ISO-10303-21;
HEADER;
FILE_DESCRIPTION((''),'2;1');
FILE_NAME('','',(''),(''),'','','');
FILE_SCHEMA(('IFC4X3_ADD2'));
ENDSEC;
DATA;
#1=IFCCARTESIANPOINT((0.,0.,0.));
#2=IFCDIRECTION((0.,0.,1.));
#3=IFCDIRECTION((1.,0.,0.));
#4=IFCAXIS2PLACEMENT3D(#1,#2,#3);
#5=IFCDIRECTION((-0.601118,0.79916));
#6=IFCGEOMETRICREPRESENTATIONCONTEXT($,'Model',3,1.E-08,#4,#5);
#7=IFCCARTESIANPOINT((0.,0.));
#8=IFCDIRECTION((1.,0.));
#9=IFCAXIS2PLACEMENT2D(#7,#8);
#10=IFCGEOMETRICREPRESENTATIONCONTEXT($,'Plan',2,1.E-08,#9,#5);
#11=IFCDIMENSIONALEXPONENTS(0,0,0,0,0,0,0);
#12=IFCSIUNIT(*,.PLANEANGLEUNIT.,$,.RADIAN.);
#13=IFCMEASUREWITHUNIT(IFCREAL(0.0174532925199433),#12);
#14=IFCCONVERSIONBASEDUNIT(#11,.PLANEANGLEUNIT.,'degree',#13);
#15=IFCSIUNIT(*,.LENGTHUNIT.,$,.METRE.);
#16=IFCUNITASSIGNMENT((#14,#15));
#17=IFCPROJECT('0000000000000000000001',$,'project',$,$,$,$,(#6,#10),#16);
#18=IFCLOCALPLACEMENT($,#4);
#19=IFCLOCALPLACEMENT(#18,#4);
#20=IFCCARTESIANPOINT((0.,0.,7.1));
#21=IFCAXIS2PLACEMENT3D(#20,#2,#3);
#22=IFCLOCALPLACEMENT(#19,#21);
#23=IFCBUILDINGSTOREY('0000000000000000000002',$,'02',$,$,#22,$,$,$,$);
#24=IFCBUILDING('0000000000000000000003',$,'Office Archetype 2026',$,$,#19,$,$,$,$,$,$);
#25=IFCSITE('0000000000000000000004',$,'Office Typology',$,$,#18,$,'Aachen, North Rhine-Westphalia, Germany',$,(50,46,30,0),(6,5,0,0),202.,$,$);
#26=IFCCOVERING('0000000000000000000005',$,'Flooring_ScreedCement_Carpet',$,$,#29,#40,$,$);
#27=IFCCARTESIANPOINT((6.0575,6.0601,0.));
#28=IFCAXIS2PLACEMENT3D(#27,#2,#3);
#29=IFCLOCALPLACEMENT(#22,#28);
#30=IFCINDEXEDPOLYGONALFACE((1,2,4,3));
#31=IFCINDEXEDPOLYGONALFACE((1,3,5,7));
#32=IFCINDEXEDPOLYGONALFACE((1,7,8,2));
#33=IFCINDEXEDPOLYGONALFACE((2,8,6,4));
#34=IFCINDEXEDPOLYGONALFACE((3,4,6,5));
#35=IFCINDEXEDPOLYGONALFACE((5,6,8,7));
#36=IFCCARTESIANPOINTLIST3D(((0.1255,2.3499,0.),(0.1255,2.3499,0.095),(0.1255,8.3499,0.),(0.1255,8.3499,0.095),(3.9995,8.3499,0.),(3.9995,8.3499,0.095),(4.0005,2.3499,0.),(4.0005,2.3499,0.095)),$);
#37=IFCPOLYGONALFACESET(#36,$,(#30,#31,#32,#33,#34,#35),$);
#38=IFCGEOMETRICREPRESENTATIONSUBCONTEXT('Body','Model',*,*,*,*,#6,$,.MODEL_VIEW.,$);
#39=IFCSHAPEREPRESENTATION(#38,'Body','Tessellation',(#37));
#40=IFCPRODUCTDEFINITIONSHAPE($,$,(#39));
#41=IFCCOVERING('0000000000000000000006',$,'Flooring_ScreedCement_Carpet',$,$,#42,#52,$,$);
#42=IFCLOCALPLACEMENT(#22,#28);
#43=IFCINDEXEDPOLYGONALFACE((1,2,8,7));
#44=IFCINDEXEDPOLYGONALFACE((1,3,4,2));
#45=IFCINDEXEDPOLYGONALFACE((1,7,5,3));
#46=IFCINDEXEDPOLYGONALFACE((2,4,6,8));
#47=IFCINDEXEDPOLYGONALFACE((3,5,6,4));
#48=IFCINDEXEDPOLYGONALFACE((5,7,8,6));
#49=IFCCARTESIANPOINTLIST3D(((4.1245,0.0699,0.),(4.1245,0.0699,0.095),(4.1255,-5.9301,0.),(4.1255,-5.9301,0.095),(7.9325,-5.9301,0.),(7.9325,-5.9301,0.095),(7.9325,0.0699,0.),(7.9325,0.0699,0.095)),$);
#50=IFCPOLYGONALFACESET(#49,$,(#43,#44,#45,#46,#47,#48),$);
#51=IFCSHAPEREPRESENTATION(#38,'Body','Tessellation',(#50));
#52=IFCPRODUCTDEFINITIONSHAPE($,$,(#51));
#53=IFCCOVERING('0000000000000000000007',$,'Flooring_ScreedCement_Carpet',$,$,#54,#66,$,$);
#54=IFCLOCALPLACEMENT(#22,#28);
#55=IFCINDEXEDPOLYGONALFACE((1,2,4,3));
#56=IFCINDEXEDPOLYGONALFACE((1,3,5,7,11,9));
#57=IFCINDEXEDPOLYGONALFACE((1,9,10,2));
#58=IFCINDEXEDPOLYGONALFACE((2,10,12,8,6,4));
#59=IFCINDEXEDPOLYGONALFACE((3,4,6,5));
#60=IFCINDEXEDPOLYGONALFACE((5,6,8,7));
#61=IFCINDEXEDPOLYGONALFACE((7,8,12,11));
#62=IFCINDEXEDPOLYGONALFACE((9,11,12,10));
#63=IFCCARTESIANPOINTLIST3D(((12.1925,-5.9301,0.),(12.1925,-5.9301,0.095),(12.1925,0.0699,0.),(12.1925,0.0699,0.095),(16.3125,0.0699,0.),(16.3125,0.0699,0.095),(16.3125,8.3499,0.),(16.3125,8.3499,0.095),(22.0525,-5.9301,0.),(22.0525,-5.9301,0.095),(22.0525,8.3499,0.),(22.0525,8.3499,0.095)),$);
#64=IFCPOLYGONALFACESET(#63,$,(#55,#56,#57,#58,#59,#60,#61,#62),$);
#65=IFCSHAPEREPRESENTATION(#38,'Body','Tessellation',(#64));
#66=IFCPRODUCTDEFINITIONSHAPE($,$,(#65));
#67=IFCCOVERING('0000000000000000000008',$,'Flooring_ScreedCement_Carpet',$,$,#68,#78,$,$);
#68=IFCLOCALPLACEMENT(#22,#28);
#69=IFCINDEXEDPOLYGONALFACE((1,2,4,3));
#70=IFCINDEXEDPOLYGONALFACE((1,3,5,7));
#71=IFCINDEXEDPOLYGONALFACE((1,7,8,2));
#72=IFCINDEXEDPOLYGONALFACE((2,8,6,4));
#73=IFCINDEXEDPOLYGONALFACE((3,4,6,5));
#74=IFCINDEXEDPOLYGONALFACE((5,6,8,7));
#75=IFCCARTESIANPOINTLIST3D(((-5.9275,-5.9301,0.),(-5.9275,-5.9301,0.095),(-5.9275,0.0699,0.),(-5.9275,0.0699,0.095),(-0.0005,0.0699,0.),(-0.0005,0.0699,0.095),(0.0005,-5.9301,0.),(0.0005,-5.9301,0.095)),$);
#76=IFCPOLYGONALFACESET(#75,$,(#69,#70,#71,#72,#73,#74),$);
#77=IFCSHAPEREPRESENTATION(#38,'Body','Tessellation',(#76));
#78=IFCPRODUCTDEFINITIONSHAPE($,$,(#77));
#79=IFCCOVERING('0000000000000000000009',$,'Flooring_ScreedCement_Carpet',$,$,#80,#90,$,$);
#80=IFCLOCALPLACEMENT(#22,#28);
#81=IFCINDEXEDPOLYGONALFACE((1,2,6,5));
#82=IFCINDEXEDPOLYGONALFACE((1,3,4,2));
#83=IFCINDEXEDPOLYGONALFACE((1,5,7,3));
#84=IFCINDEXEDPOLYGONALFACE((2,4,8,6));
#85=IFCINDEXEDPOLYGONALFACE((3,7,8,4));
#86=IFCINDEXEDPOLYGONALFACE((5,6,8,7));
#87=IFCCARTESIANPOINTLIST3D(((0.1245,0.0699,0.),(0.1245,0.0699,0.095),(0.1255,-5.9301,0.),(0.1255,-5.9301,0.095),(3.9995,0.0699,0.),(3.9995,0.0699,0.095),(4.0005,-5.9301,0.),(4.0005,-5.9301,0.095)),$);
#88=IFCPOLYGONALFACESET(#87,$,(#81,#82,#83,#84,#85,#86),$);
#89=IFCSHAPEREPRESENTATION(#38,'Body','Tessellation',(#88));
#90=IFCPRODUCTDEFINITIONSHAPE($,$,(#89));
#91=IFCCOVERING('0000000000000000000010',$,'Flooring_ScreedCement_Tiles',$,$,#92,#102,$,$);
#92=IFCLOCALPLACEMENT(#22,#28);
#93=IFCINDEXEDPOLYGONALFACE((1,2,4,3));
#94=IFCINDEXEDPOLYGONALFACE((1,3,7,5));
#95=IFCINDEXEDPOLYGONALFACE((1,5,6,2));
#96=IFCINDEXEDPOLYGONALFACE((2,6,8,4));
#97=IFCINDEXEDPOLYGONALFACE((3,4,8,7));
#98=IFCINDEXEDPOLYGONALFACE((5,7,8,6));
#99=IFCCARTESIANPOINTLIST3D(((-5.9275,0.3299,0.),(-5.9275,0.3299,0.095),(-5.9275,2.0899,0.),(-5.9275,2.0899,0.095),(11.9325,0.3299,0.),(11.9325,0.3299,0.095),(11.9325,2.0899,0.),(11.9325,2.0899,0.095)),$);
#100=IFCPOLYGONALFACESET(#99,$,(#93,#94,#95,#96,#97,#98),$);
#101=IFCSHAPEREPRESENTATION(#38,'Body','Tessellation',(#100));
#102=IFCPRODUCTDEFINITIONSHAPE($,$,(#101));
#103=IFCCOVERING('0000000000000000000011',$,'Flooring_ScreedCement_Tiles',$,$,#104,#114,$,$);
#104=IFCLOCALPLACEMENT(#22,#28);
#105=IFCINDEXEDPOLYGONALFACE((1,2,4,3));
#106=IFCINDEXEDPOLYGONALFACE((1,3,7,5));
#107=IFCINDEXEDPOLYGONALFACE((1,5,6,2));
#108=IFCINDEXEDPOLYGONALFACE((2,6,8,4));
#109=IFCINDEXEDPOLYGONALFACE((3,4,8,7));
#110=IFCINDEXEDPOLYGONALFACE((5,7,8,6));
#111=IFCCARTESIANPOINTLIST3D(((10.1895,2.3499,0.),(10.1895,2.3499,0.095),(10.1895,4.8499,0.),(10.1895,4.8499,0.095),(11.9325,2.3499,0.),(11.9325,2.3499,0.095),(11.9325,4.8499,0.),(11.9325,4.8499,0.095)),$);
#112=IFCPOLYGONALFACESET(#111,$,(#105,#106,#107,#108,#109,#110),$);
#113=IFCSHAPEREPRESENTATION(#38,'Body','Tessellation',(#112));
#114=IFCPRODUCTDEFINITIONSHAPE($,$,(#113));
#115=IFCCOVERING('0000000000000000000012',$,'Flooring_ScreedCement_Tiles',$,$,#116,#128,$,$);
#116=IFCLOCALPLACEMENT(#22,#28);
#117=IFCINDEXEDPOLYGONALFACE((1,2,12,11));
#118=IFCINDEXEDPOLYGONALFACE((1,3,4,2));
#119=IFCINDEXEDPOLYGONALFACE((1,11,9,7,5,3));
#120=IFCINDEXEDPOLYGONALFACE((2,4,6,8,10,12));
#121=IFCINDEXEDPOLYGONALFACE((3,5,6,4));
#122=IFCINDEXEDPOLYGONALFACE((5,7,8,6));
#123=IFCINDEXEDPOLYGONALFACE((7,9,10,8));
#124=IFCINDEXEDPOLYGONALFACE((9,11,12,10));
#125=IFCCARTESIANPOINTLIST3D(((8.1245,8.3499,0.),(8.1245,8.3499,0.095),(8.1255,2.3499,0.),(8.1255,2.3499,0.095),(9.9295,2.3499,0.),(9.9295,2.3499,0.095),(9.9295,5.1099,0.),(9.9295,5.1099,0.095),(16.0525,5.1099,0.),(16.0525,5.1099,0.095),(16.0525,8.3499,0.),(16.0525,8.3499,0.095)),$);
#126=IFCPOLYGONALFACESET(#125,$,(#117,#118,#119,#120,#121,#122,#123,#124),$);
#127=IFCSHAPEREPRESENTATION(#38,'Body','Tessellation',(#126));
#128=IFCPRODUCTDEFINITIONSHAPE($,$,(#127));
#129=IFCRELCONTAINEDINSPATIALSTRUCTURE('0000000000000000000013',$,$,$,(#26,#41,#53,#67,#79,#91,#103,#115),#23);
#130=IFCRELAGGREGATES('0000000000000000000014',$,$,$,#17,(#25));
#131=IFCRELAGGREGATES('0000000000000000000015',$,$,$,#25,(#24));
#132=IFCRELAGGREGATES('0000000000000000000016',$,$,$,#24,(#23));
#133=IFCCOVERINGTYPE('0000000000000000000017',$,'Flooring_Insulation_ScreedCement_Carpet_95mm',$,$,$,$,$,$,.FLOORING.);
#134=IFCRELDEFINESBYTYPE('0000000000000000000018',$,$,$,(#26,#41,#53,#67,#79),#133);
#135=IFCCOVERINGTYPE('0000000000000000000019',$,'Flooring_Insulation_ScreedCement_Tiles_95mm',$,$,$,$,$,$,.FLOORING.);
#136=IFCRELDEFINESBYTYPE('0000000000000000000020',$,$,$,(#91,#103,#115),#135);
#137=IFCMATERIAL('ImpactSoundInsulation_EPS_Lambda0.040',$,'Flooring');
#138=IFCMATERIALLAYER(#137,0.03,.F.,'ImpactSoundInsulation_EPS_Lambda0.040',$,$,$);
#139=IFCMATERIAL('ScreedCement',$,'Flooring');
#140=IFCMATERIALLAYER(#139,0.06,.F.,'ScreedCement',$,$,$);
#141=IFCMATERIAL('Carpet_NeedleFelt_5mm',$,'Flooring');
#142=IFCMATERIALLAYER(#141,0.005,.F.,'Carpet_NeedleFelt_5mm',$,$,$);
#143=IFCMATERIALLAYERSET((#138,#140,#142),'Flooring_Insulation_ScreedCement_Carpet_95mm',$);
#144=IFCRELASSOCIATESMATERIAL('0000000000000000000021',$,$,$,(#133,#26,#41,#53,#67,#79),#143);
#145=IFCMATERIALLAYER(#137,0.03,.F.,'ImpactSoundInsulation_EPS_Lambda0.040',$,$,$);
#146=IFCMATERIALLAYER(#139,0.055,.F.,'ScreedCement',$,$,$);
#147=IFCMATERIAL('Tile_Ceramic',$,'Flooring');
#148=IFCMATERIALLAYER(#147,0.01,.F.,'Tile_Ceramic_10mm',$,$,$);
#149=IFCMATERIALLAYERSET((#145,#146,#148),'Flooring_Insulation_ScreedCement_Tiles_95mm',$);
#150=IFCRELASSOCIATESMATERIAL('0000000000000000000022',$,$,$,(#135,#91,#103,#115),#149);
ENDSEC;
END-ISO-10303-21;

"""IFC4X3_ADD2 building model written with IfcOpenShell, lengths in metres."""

from ifc_helpers import new_model, entity, si_unit, converted_unit, direction, frame, origin_with_axes, origin_2d_with_axis, place, context, subcontext, project, spatial, line, indexed_curve, outline, extrude, material, layer, layer_set, layer_usage, type_object, element, save


model = new_model("IFC4X3_ADD2")

# Units and contexts
model_context = context("Model", 3, precision=1e-08, world=origin_with_axes(), true_north=direction((-0.601118, 0.79916)))
plan_context = context("Plan", 2, precision=1e-08, world=origin_2d_with_axis(), true_north=direction((-0.601118, 0.79916)))
body_context = subcontext(model_context, "Body", "Model", "MODEL_VIEW")
ifc_project = project(units=[converted_unit("PLANEANGLEUNIT", "degree", entity("IfcReal", 0.0174532925199433), si_unit("PLANEANGLEUNIT", "RADIAN"), dimensions=[0, 0, 0, 0, 0, 0, 0]), si_unit("LENGTHUNIT", "METRE")], contexts=[model_context, plan_context])

# Site, building, storey
site_placement = place(None, origin_with_axes())
site = spatial("IfcSite", under=ifc_project, at=site_placement, Name="Office Typology", LongName="Aachen, North Rhine-Westphalia, Germany", RefLatitude=(50, 46, 30, 0), RefLongitude=(6, 5, 0, 0), RefElevation=202.0)
building_placement = place(site_placement, origin_with_axes())
building = spatial("IfcBuilding", under=site, at=building_placement, Name="Office Archetype 2026")
storey_placement = place(building_placement, frame((0.0, 0.0, 7.1), z_axis=(0.0, 0.0, 1.0), x_axis=(1.0, 0.0, 0.0)))
storey = spatial("IfcBuildingStorey", under=building, at=storey_placement, Name="02")

# Coverings
ifc_material_1 = material(Name="ImpactSoundInsulation_EPS_Lambda0.040", Category="Flooring")
ifc_layer_1 = layer(ifc_material_1, 0.03, ventilated=False, Name="ImpactSoundInsulation_EPS_Lambda0.040")
ifc_material_2 = material(Name="ScreedCement", Category="Flooring")
ifc_layer_2 = layer(ifc_material_2, 0.06, ventilated=False, Name="ScreedCement")
ifc_material_3 = material(Name="Carpet_NeedleFelt_5mm", Category="Flooring")
ifc_layer_3 = layer(ifc_material_3, 0.005, ventilated=False, Name="Carpet_NeedleFelt_5mm")
ifc_layer_set_1 = layer_set([ifc_layer_1, ifc_layer_2, ifc_layer_3], Name="Flooring_Insulation_ScreedCement_Carpet_95mm")
ifc_layer_usage_1 = layer_usage(ifc_layer_set_1, "AXIS3", "POSITIVE", 0.0)
covering_type_1 = type_object("IfcCoveringType", Name="Flooring_Insulation_ScreedCement_Carpet_95mm", PredefinedType="FLOORING", material=ifc_layer_set_1)
covering_1_placement = place(storey_placement, frame((6.0575, 6.0601, 0.0), z_axis=(0.0, 0.0, 1.0), x_axis=(1.0, 0.0, 0.0)))
element("IfcCovering", 1, at=covering_1_placement, inside=storey, type_object=covering_type_1, material=ifc_layer_usage_1, Name="Flooring_ScreedCement_Carpet", context=body_context, shape_type="SweptSolid", body=[
    extrude(outline(indexed_curve([(0.1255, 2.3499), (0.1255, 8.3499), (3.9995, 8.3499), (4.0005, 2.3499)], segments=[line(1, 2, 3, 4, 1)])), origin_with_axes(), (0.0, 0.0, 1.0), 0.095),
])
ifc_layer_usage_2 = layer_usage(ifc_layer_set_1, "AXIS3", "POSITIVE", 0.0)
covering_2_placement = place(storey_placement, frame((6.0575, 6.0601, 0.0), z_axis=(0.0, 0.0, 1.0), x_axis=(1.0, 0.0, 0.0)))
element("IfcCovering", 2, at=covering_2_placement, inside=storey, type_object=covering_type_1, material=ifc_layer_usage_2, Name="Flooring_ScreedCement_Carpet", context=body_context, shape_type="SweptSolid", body=[
    extrude(outline(indexed_curve([(4.1245, 0.0699), (7.9325, 0.0699), (7.9325, -5.9301), (4.1255, -5.9301)], segments=[line(1, 2, 3, 4, 1)])), origin_with_axes(), (0.0, 0.0, 1.0), 0.095),
])
ifc_layer_usage_3 = layer_usage(ifc_layer_set_1, "AXIS3", "POSITIVE", 0.0)
covering_3_placement = place(storey_placement, frame((6.0575, 6.0601, 0.0), z_axis=(0.0, 0.0, 1.0), x_axis=(1.0, 0.0, 0.0)))
element("IfcCovering", 3, at=covering_3_placement, inside=storey, type_object=covering_type_1, material=ifc_layer_usage_3, Name="Flooring_ScreedCement_Carpet", context=body_context, shape_type="SweptSolid", body=[
    extrude(outline(indexed_curve([(16.3125, 8.3499), (22.0525, 8.3499), (22.0525, -5.9301), (12.1925, -5.9301), (12.1925, 0.0699), (16.3125, 0.0699)], segments=[line(1, 2, 3, 4, 5, 6, 1)])), origin_with_axes(), (0.0, 0.0, 1.0), 0.095),
])
ifc_layer_usage_4 = layer_usage(ifc_layer_set_1, "AXIS3", "POSITIVE", 0.0)
covering_4_placement = place(storey_placement, frame((6.0575, 6.0601, 0.0), z_axis=(0.0, 0.0, 1.0), x_axis=(1.0, 0.0, 0.0)))
element("IfcCovering", 4, at=covering_4_placement, inside=storey, type_object=covering_type_1, material=ifc_layer_usage_4, Name="Flooring_ScreedCement_Carpet", context=body_context, shape_type="SweptSolid", body=[
    extrude(outline(indexed_curve([(-5.9275, -5.9301), (-5.9275, 0.0699), (-0.0005, 0.0699), (0.0005, -5.9301)], segments=[line(1, 2, 3, 4, 1)])), origin_with_axes(), (0.0, 0.0, 1.0), 0.095),
])
ifc_layer_usage_5 = layer_usage(ifc_layer_set_1, "AXIS3", "POSITIVE", 0.0)
covering_5_placement = place(storey_placement, frame((6.0575, 6.0601, 0.0), z_axis=(0.0, 0.0, 1.0), x_axis=(1.0, 0.0, 0.0)))
element("IfcCovering", 5, at=covering_5_placement, inside=storey, type_object=covering_type_1, material=ifc_layer_usage_5, Name="Flooring_ScreedCement_Carpet", context=body_context, shape_type="SweptSolid", body=[
    extrude(outline(indexed_curve([(0.1255, -5.9301), (0.1245, 0.0699), (3.9995, 0.0699), (4.0005, -5.9301)], segments=[line(1, 2, 3, 4, 1)])), origin_with_axes(), (0.0, 0.0, 1.0), 0.095),
])
ifc_layer_4 = layer(ifc_material_1, 0.03, ventilated=False, Name="ImpactSoundInsulation_EPS_Lambda0.040")
ifc_layer_5 = layer(ifc_material_2, 0.055, ventilated=False, Name="ScreedCement")
ifc_material_4 = material(Name="Tile_Ceramic", Category="Flooring")
ifc_layer_6 = layer(ifc_material_4, 0.01, ventilated=False, Name="Tile_Ceramic_10mm")
ifc_layer_set_2 = layer_set([ifc_layer_4, ifc_layer_5, ifc_layer_6], Name="Flooring_Insulation_ScreedCement_Tiles_95mm")
ifc_layer_usage_6 = layer_usage(ifc_layer_set_2, "AXIS3", "POSITIVE", 0.0)
covering_type_2 = type_object("IfcCoveringType", Name="Flooring_Insulation_ScreedCement_Tiles_95mm", PredefinedType="FLOORING", material=ifc_layer_set_2)
covering_6_placement = place(storey_placement, frame((6.0575, 6.0601, 0.0), z_axis=(0.0, 0.0, 1.0), x_axis=(1.0, 0.0, 0.0)))
element("IfcCovering", 6, at=covering_6_placement, inside=storey, type_object=covering_type_2, material=ifc_layer_usage_6, Name="Flooring_ScreedCement_Tiles", context=body_context, shape_type="SweptSolid", body=[
    extrude(outline(indexed_curve([(-5.9275, 0.3299), (-5.9275, 2.0899), (11.9325, 2.0899), (11.9325, 0.3299)], segments=[line(1, 2, 3, 4, 1)])), None, (0.0, 0.0, 1.0), 0.095),
])
ifc_layer_usage_7 = layer_usage(ifc_layer_set_2, "AXIS3", "POSITIVE", 0.0)
covering_7_placement = place(storey_placement, frame((6.0575, 6.0601, 0.0), z_axis=(0.0, 0.0, 1.0), x_axis=(1.0, 0.0, 0.0)))
element("IfcCovering", 7, at=covering_7_placement, inside=storey, type_object=covering_type_2, material=ifc_layer_usage_7, Name="Flooring_ScreedCement_Tiles", context=body_context, shape_type="SweptSolid", body=[
    extrude(outline(indexed_curve([(11.9325, 4.8499), (11.9325, 2.3499), (10.1895, 2.3499), (10.1895, 4.8499)], segments=[line(1, 2, 3, 4, 1)])), None, (0.0, 0.0, 1.0), 0.095),
])
ifc_layer_usage_8 = layer_usage(ifc_layer_set_2, "AXIS3", "POSITIVE", 0.0)
covering_8_placement = place(storey_placement, frame((6.0575, 6.0601, 0.0), z_axis=(0.0, 0.0, 1.0), x_axis=(1.0, 0.0, 0.0)))
element("IfcCovering", 8, at=covering_8_placement, inside=storey, type_object=covering_type_2, material=ifc_layer_usage_8, Name="Flooring_ScreedCement_Tiles", context=body_context, shape_type="SweptSolid", body=[
    extrude(outline(indexed_curve([(9.9295, 2.3499), (8.1255, 2.3499), (8.1245, 8.3499), (16.0525, 8.3499), (16.0525, 5.1099), (9.9295, 5.1099)], segments=[line(1, 2, 3, 4, 5, 6, 1)])), None, (0.0, 0.0, 1.0), 0.095),
])

save(model, "model.ifc")
